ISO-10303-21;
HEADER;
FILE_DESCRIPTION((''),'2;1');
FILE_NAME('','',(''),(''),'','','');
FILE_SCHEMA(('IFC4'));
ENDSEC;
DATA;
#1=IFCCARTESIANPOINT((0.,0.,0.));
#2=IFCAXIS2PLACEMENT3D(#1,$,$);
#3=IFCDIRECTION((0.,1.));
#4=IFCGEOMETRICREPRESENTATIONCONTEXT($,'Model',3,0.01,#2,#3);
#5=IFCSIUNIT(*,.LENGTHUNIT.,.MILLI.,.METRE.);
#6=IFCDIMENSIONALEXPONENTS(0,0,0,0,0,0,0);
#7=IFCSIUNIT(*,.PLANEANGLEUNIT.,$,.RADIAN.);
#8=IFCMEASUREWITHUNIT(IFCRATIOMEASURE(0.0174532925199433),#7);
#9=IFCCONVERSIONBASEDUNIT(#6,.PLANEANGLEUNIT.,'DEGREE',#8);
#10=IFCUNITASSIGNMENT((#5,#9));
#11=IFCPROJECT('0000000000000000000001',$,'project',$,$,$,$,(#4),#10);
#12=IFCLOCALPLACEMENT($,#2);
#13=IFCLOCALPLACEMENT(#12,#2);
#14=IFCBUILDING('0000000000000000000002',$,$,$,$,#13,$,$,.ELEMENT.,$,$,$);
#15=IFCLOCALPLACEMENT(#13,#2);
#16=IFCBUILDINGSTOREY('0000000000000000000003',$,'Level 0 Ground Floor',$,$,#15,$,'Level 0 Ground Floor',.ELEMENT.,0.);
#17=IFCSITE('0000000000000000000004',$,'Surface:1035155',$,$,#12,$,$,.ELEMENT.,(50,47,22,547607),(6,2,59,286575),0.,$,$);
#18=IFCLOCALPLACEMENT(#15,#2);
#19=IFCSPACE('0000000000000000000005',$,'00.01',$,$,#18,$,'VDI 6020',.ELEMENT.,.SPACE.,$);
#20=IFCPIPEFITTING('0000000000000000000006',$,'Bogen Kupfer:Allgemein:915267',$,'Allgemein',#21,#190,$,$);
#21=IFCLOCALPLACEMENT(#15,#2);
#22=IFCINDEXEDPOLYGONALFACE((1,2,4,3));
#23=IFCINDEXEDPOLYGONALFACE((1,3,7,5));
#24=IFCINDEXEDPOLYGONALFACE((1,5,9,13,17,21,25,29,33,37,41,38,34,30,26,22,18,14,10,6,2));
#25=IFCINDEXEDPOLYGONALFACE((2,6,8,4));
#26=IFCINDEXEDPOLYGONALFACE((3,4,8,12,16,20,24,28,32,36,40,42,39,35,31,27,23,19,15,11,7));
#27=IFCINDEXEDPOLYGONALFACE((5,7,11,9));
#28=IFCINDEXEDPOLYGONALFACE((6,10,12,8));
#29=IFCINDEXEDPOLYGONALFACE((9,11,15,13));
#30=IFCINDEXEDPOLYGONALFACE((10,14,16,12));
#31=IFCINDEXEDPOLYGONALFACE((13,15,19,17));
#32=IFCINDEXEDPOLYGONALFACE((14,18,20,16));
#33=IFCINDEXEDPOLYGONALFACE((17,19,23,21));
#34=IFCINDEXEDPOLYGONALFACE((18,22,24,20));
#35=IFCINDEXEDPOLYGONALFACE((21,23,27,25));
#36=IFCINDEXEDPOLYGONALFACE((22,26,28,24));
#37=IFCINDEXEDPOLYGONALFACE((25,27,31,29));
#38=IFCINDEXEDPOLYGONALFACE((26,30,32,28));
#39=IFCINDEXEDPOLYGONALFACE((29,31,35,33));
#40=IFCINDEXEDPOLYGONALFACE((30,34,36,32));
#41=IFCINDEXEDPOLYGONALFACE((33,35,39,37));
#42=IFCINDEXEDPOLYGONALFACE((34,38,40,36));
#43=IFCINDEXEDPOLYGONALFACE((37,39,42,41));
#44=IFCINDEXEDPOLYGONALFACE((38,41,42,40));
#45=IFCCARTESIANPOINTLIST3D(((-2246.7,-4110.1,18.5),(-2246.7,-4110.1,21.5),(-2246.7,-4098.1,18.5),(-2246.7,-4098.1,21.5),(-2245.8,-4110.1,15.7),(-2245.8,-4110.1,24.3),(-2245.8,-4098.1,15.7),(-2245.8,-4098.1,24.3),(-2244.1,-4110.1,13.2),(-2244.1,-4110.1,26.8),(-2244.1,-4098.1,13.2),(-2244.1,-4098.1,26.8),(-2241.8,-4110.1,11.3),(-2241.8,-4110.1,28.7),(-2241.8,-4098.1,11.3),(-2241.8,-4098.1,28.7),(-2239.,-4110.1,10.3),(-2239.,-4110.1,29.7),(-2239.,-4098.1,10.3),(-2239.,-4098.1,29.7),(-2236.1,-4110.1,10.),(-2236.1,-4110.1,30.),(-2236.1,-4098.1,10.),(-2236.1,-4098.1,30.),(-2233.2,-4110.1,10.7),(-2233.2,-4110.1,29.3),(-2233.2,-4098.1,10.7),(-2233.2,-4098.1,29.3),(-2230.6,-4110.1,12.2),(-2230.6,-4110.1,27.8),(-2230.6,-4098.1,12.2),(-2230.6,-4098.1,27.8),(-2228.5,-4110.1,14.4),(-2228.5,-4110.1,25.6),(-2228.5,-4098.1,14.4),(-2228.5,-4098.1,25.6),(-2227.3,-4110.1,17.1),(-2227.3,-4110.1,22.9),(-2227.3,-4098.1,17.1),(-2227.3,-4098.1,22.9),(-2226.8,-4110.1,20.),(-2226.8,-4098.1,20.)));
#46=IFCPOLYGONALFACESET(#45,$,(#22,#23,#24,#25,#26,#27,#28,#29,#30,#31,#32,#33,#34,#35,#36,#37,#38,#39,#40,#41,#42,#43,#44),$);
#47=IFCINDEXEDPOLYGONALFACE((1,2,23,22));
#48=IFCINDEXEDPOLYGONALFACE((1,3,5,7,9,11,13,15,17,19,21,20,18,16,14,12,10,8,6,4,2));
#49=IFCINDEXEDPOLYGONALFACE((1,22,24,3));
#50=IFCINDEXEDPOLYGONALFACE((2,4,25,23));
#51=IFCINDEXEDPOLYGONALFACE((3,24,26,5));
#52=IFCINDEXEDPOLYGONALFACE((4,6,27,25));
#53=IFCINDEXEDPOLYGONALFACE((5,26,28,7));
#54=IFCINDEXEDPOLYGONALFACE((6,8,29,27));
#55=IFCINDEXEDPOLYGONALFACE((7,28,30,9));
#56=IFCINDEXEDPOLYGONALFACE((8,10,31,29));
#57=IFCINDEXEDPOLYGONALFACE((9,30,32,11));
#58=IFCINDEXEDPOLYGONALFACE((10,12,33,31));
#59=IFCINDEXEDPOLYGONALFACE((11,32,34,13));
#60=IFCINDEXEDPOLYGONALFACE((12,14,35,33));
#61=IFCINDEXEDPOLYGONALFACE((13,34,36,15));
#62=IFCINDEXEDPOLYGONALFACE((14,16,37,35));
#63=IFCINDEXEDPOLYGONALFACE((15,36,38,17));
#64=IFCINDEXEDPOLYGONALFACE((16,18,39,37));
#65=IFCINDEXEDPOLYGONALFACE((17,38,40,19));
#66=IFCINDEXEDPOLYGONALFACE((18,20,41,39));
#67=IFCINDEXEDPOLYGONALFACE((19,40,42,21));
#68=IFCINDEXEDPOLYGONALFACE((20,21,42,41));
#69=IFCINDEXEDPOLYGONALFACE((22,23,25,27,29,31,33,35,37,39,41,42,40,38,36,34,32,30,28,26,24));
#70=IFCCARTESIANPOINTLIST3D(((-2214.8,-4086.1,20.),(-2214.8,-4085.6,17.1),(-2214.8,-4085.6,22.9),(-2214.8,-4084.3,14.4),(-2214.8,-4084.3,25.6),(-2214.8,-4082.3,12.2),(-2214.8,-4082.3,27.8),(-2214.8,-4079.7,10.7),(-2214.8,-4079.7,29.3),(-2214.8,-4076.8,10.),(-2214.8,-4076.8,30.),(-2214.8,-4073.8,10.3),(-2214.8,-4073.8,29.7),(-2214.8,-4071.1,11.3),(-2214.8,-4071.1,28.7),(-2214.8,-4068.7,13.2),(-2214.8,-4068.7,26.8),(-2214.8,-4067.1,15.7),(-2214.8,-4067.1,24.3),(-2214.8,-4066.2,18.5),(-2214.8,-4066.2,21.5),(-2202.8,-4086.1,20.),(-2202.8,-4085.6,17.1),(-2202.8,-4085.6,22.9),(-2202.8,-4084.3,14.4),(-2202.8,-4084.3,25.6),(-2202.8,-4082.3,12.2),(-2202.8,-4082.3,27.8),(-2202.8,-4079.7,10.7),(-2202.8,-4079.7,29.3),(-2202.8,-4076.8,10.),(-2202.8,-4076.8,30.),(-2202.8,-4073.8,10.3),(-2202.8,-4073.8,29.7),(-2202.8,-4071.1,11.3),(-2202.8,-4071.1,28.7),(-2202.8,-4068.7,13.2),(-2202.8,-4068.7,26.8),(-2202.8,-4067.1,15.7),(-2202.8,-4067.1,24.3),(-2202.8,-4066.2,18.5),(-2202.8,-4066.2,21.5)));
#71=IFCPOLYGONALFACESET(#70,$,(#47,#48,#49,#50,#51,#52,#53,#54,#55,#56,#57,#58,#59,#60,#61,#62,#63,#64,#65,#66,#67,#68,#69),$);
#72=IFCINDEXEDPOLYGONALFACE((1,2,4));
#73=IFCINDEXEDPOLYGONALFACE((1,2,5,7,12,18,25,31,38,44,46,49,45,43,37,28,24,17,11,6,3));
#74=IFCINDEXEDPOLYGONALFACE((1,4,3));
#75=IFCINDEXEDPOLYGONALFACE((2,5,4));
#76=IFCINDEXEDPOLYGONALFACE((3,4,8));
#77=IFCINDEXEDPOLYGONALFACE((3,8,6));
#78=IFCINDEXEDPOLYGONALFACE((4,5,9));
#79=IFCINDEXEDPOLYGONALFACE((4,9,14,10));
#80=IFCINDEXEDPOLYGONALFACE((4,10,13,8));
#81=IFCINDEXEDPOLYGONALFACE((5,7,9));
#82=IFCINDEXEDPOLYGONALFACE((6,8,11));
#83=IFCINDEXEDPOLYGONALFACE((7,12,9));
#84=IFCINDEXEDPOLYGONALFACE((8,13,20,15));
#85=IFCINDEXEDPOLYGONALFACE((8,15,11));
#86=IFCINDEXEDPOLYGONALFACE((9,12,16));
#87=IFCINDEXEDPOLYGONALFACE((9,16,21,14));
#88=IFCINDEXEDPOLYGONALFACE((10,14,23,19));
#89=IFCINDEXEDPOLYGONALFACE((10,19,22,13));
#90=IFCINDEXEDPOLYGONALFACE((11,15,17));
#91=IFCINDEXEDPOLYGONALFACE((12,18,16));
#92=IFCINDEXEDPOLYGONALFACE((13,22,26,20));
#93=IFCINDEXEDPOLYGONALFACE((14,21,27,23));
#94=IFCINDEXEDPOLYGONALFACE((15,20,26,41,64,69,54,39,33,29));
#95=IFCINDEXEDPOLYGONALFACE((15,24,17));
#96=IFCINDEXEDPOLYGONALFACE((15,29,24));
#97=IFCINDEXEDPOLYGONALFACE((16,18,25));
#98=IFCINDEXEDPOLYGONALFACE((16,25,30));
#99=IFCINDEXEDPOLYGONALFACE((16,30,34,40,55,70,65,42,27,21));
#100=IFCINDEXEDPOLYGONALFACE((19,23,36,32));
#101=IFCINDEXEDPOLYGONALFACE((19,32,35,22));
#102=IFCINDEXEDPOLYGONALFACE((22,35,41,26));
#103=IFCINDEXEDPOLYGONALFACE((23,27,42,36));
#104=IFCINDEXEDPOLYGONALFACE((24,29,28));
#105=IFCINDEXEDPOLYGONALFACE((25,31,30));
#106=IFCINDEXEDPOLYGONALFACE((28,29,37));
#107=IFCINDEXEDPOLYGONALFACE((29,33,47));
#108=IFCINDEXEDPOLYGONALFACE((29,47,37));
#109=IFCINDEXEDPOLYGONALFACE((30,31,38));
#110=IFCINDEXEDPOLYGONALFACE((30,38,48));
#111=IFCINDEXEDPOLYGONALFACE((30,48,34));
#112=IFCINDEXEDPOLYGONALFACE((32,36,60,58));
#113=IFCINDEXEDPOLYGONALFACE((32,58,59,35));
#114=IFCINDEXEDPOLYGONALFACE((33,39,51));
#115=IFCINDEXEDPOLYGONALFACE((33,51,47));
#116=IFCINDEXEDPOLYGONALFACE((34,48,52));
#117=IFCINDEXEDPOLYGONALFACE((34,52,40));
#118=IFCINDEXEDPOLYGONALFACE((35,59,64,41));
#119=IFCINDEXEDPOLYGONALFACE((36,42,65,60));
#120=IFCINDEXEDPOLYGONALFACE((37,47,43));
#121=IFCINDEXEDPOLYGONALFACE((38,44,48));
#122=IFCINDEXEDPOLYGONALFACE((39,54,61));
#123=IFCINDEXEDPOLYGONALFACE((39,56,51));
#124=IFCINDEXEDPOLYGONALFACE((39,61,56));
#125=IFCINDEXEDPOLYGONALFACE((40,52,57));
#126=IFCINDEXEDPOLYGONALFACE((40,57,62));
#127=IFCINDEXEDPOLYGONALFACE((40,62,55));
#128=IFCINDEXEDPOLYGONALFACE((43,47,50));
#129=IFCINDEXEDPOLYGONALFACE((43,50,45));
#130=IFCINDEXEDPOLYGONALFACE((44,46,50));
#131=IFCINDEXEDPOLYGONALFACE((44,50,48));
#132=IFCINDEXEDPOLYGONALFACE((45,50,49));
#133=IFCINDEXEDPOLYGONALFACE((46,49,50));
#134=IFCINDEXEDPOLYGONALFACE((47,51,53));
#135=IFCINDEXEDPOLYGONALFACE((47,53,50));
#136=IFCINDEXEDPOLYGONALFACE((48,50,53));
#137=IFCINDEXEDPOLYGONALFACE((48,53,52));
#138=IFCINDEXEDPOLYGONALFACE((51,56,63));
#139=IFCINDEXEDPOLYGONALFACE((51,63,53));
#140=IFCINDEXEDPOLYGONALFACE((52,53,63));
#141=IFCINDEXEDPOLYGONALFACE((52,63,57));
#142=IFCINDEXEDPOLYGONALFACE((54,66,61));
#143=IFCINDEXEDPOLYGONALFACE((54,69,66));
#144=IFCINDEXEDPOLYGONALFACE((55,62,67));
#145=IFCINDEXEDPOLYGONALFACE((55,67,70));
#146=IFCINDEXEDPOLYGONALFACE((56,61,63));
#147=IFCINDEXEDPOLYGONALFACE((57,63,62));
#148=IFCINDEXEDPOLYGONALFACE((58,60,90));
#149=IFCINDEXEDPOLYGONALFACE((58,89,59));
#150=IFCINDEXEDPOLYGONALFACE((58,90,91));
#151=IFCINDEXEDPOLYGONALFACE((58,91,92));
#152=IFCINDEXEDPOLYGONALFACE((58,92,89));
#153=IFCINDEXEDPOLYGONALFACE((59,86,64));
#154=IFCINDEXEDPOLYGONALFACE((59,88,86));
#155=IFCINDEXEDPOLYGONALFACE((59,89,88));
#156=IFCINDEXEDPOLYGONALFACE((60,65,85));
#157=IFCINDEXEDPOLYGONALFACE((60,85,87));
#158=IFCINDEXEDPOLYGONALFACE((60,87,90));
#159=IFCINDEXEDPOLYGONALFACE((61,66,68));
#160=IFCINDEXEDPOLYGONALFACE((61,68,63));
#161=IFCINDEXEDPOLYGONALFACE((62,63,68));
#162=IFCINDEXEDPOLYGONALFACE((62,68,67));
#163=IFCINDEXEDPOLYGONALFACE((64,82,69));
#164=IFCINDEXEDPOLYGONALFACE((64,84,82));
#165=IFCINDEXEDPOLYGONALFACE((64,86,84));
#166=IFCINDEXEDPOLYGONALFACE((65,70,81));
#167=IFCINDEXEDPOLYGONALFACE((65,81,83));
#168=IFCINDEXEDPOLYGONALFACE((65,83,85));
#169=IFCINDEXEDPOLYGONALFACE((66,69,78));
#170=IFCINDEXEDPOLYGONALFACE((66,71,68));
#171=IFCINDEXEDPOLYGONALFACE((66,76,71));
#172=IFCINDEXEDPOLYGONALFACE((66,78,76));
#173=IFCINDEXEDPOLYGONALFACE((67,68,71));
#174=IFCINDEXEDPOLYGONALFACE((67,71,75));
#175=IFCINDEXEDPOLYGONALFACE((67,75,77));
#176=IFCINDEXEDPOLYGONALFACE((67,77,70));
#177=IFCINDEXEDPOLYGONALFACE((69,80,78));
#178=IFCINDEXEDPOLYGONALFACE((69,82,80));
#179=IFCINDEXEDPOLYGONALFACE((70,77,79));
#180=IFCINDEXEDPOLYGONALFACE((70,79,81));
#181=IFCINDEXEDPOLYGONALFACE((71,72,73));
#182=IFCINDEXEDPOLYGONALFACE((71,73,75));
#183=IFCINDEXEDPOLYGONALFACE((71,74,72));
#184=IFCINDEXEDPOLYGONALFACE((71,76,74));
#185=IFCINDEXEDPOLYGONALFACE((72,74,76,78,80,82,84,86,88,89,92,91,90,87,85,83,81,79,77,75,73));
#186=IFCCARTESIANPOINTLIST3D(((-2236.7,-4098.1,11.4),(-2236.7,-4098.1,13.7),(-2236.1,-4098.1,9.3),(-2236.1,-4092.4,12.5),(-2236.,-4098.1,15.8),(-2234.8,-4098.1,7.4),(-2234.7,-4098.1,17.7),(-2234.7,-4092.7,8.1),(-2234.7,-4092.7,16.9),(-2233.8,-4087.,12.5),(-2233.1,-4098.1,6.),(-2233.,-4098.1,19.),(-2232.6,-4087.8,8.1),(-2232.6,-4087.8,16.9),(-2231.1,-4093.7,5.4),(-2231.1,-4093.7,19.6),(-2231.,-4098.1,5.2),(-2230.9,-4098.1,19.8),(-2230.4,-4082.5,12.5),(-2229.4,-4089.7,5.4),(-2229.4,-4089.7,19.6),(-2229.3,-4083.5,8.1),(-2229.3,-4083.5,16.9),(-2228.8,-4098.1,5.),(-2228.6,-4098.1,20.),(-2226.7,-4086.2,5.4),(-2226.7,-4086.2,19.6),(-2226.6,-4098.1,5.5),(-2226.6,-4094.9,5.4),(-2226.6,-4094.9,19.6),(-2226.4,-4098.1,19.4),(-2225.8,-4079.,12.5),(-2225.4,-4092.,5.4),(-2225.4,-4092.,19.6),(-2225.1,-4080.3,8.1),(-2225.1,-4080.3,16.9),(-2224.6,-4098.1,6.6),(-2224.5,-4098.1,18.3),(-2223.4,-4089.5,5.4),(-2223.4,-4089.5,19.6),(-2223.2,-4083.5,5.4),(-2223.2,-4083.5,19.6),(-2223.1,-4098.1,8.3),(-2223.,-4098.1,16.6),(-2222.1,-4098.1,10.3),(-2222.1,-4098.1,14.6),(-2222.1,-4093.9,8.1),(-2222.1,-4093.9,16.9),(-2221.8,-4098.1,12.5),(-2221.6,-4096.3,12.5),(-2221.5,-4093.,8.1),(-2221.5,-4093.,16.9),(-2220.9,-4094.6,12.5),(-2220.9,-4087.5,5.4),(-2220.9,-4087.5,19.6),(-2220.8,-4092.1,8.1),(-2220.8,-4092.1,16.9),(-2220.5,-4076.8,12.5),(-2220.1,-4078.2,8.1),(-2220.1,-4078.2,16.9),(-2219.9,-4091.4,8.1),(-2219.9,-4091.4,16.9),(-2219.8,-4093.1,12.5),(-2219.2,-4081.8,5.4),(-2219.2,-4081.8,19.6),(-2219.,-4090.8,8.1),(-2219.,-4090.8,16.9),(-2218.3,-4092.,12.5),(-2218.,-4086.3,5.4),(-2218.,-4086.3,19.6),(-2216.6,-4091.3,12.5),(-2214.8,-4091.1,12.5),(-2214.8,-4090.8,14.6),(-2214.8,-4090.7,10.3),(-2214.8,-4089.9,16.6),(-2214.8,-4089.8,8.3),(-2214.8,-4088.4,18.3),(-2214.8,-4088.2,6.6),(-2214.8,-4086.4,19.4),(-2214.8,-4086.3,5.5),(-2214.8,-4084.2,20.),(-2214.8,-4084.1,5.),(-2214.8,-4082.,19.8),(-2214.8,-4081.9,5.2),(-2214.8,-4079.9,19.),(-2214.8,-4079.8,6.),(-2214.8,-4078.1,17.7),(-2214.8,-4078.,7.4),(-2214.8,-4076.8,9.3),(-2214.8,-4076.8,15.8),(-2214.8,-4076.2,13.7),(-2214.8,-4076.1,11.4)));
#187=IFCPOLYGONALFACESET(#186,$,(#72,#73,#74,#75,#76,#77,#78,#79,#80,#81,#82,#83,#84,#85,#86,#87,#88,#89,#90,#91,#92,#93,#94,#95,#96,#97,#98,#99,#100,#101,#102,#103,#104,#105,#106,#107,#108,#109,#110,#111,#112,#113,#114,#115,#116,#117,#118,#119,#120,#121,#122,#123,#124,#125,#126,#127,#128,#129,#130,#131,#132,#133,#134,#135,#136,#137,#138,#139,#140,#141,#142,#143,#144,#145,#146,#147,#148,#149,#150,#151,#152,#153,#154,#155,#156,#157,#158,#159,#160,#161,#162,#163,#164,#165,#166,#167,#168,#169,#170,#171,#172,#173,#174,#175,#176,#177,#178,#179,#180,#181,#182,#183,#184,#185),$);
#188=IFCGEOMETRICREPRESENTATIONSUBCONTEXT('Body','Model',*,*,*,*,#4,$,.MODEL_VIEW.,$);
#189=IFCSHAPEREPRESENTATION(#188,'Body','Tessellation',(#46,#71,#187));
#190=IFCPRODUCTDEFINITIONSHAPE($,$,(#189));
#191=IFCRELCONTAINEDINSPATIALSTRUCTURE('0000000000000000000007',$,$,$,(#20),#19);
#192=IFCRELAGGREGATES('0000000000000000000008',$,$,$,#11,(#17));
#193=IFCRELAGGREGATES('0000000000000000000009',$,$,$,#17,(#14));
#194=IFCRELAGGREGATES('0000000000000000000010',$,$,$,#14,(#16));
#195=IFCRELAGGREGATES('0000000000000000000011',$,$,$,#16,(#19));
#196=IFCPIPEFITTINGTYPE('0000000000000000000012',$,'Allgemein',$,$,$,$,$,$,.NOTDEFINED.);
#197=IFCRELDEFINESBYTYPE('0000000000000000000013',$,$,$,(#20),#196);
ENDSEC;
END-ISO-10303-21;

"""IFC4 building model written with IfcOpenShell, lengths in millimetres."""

from ifc_helpers import new_model, entity, si_unit, converted_unit, direction, frame, frame_2d, origin, place, context, subcontext, project, spatial, circle, extrude, source, transform, mapped, type_object, type_shapes, element, save


model = new_model("IFC4")

# Units and contexts
model_context = context("Model", 3, precision=0.01, world=origin(), true_north=direction((0.0, 1.0)))
body_context = subcontext(model_context, "Body", "Model", "MODEL_VIEW")
ifc_project = project(units=[si_unit("LENGTHUNIT", "METRE", prefix="MILLI"), converted_unit("PLANEANGLEUNIT", "DEGREE", entity("IfcRatioMeasure", 0.0174532925199433), si_unit("PLANEANGLEUNIT", "RADIAN"), dimensions=[0, 0, 0, 0, 0, 0, 0])], contexts=[model_context])

# Site, building, storey
site_placement = place(None, origin())
site = spatial("IfcSite", under=ifc_project, at=site_placement, Name="Surface:1035155", CompositionType="ELEMENT", RefLatitude=(50, 47, 22, 547607), RefLongitude=(6, 2, 59, 286575), RefElevation=0.0)
building_placement = place(site_placement, origin())
building = spatial("IfcBuilding", under=site, at=building_placement, CompositionType="ELEMENT")
storey_placement = place(building_placement, origin())
storey = spatial("IfcBuildingStorey", under=building, at=storey_placement, Name="Level 0 Ground Floor", LongName="Level 0 Ground Floor", CompositionType="ELEMENT", Elevation=0.0)

# Shared definitions
pipe_fitting_type = type_object("IfcPipeFittingType", Name="Allgemein", PredefinedType="NOTDEFINED")
ifc_direction = entity("IfcDirection", [0.0, 0.0, -1.0])
trimmed_curve = entity("IfcTrimmedCurve", entity("IfcCircle", entity("IfcAxis2Placement2D", entity("IfcCartesianPoint", [-14.5, 0.0]), entity("IfcDirection", [0.0, 1.0])), 14.5), [entity("IfcParameterValue", 270.0)], [entity("IfcParameterValue", 0.0)], True, "PARAMETER")
shared_shape_1 = source(origin(), body_context, "Body", "SolidModel", [
    extrude(circle(Radius=10.0, at=frame_2d((0.0, 0.0), x_axis=(1.0, 0.0))), frame((0.0, 22.0, 0.0), z_axis=(0.0, 1.0, 0.0), x_axis=(-1.0, 0.0, 0.0)), (0.0, 0.0, 1.0), 12.0),
    extrude(circle(Radius=10.0, at=frame_2d((0.0, 0.0), x_axis=(1.0, 0.0))), frame((-34.0, 0.0, 0.0), z_axis=(1.0, 0.0, 0.0), x_axis=(0.0, 1.0, 0.0)), (0.0, 0.0, 1.0), 12.0),
    entity("IfcSurfaceCurveSweptAreaSolid", entity("IfcCircleProfileDef", "AREA", None, entity("IfcAxis2Placement2D", entity("IfcCartesianPoint", [0.0, 7.5]), entity("IfcDirection", [1.0, 0.0])), 7.5), entity("IfcAxis2Placement3D", entity("IfcCartesianPoint", [-7.5, 22.0, 0.0]), ifc_direction, entity("IfcDirection", [1.0, 0.0, 0.0])), trimmed_curve, 0.0, 90.0, entity("IfcSurfaceOfLinearExtrusion", entity("IfcArbitraryOpenProfileDef", "CURVE", None, trimmed_curve), entity("IfcAxis2Placement3D", entity("IfcCartesianPoint", [0.0, 0.0, -304.8])), ifc_direction, 1.0)),
])
type_shapes(pipe_fitting_type, [shared_shape_1])

# Shared definitions
space_placement = place(storey_placement, origin())
space = spatial("IfcSpace", under=storey, at=space_placement, Name="00.01", LongName="VDI 6020", CompositionType="ELEMENT", PredefinedType="SPACE")

# Pipe fitting
for number, where, z_axis, x_axis, name in (
    (1, (-2236.8, -4076.1, 20.0), (0.0, 0.0, 1.0), (-1.0, 0.0, 0.0), "Bogen Kupfer:Allgemein:915267"),
):
    element("IfcPipeFitting", number, at=place(space_placement, frame(where, z_axis=z_axis, x_axis=x_axis)), inside=space, type_object=pipe_fitting_type, Name=name, ObjectType="Allgemein", context=body_context, shape_type="MappedRepresentation", body=[
        mapped(shared_shape_1, transform((0.0, 0.0, 0.0), scale=1.0)),
    ])

save(model, "model.ifc")
